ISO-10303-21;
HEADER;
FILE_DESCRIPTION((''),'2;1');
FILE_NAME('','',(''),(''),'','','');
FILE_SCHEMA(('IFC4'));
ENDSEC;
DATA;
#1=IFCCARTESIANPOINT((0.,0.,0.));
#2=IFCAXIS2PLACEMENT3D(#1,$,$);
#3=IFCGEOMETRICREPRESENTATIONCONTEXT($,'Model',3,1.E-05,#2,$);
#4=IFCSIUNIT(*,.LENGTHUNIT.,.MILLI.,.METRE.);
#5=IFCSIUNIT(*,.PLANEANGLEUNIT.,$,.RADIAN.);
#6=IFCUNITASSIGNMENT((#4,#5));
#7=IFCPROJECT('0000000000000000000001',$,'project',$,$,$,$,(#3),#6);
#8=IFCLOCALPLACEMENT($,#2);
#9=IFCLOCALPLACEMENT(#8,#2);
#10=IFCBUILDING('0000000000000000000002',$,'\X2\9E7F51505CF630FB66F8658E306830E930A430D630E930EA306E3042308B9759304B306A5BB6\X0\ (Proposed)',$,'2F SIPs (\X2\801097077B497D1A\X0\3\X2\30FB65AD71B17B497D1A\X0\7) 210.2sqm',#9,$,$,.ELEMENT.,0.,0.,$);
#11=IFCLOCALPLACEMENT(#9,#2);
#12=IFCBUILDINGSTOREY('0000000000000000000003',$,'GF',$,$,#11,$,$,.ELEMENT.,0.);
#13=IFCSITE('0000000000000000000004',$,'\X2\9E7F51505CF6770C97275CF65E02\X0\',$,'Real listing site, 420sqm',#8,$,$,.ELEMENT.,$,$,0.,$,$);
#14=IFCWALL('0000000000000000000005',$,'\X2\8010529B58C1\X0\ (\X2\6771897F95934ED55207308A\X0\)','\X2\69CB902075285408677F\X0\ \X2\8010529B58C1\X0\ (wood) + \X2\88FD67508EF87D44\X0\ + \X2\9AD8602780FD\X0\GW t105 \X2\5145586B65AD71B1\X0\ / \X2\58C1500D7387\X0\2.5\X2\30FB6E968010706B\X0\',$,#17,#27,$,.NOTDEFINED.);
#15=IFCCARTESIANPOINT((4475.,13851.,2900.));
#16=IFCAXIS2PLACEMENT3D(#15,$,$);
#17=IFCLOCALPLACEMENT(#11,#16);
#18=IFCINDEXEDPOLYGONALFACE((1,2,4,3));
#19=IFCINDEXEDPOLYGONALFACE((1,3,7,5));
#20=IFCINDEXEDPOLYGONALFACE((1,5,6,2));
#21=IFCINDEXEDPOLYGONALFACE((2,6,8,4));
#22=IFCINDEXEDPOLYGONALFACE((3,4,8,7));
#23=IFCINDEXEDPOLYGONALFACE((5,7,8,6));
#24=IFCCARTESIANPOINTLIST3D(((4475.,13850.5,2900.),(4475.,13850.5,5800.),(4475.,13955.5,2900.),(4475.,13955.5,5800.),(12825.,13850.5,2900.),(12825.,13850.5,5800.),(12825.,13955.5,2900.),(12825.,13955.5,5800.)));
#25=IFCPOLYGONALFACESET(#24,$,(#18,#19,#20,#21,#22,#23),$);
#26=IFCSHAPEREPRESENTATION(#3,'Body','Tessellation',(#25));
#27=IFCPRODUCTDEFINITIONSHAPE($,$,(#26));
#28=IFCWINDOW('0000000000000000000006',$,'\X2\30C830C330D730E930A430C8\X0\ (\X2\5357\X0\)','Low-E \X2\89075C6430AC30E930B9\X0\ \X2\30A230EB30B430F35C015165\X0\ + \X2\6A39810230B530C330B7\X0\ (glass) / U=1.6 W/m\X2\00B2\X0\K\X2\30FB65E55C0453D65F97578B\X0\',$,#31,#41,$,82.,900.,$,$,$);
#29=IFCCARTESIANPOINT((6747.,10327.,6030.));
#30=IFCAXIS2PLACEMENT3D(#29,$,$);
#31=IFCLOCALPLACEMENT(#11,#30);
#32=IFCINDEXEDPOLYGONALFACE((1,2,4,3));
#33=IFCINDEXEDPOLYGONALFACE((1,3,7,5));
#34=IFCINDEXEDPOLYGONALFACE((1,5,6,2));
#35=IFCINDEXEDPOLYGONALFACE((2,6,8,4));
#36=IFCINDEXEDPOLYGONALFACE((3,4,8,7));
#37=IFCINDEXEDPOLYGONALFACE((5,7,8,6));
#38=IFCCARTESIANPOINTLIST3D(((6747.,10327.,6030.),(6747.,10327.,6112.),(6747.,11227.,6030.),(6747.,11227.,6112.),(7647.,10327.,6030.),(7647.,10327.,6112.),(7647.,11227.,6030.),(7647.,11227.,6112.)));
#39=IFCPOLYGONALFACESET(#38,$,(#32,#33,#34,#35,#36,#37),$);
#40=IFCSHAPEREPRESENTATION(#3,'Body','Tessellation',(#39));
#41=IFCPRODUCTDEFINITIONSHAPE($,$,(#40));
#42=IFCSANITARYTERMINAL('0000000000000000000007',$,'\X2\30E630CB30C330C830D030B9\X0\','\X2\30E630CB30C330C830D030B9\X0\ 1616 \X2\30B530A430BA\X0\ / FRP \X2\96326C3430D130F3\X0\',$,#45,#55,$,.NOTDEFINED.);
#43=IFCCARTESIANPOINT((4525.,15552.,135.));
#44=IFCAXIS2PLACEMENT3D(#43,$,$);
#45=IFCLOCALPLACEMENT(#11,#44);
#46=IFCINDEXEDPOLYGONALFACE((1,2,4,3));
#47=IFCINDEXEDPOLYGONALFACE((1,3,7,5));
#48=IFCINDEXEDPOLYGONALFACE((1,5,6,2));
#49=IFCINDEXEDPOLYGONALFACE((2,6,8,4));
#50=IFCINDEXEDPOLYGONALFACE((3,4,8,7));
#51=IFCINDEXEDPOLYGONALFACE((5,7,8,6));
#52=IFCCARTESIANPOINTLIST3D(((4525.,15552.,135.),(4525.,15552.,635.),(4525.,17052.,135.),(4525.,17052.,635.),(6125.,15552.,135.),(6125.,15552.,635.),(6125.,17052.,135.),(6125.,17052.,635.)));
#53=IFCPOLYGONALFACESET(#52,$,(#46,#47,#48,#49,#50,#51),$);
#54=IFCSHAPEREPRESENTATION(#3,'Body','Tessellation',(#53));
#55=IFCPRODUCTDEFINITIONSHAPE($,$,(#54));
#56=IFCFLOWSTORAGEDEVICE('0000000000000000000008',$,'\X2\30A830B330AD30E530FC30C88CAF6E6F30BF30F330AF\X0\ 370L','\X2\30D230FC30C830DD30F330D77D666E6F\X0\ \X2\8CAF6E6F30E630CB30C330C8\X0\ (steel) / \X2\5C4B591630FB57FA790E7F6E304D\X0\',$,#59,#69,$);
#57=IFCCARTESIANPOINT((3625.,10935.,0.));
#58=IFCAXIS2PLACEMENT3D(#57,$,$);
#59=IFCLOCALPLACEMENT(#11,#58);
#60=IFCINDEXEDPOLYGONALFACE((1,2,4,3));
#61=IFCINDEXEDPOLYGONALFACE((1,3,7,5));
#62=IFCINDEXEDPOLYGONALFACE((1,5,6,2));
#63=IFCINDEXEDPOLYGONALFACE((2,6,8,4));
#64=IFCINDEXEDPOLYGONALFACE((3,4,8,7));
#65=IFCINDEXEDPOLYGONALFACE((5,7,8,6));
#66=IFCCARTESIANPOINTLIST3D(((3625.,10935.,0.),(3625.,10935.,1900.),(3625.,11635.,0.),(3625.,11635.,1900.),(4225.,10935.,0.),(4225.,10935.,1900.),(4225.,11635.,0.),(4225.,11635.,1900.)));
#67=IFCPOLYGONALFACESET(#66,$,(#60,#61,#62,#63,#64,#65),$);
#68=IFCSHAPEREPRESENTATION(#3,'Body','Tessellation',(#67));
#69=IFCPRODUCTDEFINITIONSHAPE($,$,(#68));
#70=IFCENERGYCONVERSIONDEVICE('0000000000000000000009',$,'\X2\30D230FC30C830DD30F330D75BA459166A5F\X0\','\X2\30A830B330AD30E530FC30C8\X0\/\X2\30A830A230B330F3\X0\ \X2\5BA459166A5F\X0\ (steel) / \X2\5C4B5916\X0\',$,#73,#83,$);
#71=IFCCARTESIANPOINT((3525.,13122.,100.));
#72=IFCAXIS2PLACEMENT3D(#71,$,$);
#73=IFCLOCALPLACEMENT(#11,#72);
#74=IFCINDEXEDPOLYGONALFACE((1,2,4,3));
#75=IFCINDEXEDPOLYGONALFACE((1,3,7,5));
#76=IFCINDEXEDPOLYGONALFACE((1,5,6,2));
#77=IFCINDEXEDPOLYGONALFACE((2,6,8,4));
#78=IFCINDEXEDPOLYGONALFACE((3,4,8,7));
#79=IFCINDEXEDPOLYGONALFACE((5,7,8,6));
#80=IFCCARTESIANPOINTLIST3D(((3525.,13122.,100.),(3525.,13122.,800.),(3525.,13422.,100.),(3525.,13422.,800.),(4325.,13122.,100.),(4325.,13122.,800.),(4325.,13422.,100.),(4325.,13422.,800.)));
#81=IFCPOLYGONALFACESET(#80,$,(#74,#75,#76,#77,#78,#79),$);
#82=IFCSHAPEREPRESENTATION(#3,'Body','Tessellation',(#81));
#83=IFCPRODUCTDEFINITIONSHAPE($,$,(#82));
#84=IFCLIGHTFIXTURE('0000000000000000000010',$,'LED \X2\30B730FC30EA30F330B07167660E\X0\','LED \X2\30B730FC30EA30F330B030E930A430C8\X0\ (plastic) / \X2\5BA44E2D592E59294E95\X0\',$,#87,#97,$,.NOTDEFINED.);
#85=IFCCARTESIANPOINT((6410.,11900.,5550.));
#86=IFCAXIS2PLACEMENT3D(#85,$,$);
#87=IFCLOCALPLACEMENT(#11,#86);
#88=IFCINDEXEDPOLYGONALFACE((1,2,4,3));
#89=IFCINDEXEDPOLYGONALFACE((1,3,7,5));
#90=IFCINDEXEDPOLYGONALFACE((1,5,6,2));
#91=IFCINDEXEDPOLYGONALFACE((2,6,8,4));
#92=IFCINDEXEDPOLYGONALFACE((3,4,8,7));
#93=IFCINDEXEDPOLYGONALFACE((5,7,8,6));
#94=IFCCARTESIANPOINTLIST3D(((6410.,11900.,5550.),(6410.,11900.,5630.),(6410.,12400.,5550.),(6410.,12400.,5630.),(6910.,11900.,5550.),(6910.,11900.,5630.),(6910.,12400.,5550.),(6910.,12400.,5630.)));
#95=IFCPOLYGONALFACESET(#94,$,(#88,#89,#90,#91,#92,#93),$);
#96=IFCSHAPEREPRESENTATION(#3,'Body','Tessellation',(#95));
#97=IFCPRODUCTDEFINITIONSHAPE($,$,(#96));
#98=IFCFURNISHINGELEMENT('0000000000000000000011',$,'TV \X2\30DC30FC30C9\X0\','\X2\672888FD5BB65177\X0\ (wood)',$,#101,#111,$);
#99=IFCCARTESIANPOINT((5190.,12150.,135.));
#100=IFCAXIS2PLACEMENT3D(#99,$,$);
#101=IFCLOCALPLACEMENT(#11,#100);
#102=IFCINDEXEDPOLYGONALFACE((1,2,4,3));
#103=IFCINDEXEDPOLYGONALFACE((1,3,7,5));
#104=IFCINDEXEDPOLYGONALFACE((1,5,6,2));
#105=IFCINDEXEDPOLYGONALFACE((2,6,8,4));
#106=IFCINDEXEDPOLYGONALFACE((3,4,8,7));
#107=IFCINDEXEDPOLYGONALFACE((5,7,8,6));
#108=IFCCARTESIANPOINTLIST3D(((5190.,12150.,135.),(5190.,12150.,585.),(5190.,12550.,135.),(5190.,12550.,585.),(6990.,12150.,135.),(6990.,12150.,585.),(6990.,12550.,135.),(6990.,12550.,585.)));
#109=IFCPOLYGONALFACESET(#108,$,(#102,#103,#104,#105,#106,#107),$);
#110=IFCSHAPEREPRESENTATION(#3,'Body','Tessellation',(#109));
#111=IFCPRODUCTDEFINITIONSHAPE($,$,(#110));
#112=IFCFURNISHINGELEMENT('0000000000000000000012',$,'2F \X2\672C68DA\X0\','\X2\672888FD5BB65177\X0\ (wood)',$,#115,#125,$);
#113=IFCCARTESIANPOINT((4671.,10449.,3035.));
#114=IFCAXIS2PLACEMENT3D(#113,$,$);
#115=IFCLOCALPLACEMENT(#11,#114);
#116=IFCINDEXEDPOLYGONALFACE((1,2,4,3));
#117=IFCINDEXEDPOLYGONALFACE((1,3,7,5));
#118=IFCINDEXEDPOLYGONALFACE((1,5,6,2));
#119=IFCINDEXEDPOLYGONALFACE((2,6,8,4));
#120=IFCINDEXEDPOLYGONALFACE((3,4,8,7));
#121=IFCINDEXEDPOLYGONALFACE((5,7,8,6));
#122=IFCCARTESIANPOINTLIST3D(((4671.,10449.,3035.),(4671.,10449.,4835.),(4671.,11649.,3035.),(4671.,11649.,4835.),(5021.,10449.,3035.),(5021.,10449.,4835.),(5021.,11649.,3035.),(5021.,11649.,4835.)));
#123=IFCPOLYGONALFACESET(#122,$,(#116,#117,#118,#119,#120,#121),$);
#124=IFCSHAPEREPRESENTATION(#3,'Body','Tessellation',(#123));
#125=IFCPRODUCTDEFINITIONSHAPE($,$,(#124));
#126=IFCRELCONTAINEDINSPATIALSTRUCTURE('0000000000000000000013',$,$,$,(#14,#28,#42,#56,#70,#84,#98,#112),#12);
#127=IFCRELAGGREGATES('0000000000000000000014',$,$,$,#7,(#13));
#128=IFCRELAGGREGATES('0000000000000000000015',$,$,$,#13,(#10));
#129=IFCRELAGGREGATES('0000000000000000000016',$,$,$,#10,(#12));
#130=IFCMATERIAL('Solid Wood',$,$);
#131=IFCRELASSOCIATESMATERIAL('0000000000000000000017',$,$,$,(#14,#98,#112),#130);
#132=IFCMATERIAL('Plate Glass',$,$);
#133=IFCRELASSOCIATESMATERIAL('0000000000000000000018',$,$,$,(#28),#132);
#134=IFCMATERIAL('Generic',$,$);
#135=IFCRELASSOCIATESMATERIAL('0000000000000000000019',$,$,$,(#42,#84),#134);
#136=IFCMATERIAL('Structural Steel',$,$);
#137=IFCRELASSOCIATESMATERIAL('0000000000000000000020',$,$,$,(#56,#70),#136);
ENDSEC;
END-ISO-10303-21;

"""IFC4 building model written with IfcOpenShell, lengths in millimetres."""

from ifc_helpers import new_model, si_unit, frame, frame_2d, origin, place, context, project, spatial, rectangle, extrude, material, element, save


model = new_model("IFC4")

# Units and contexts
model_context = context("Model", 3, precision=1e-05, world=origin())
ifc_project = project(units=[si_unit("LENGTHUNIT", "METRE", prefix="MILLI"), si_unit("PLANEANGLEUNIT", "RADIAN")], contexts=[model_context])

# Site, building, storey
site_placement = place(None, origin())
site = spatial("IfcSite", under=ifc_project, at=site_placement, Name="鹿児島県霧島市", ObjectType="Real listing site, 420sqm", CompositionType="ELEMENT", RefElevation=0.0)
building_placement = place(site_placement, origin())
building = spatial("IfcBuilding", under=site, at=building_placement, Name="鹿児島・書斎とライブラリのある静かな家 (Proposed)", ObjectType="2F SIPs (耐震等級3・断熱等級7) 210.2sqm", CompositionType="ELEMENT", ElevationOfRefHeight=0.0, ElevationOfTerrain=0.0)
storey_placement = place(building_placement, origin())
storey = spatial("IfcBuildingStorey", under=building, at=storey_placement, Name="GF", CompositionType="ELEMENT", Elevation=0.0)

# Shared definitions
ifc_material_1 = material(Name="Solid Wood")

# Wall
wall_1_placement = place(storey_placement, frame((4475.0, 13851.0, 2900.0)))
element("IfcWall", 1, at=wall_1_placement, inside=storey, material=ifc_material_1, Name="耐力壁 (東西間仕切り)", Description="構造用合板 耐力壁 (wood) + 製材軸組 + 高性能GW t105 充填断熱 / 壁倍率2.5・準耐火", PredefinedType="NOTDEFINED", context=model_context, shape_type="SweptSolid", body=[
    extrude(rectangle(XDim=8350.0, YDim=105.0, at=frame_2d((4175.0, 52.0))), frame((4475.0, 13851.0, 2900.0)), (0.0, 0.0, 1.0), 2900.0),
])

# Window
ifc_material_2 = material(Name="Plate Glass")
window_placement = place(storey_placement, frame((6747.0, 10327.0, 6030.0)))
element("IfcWindow", 2, at=window_placement, inside=storey, material=ifc_material_2, Name="トップライト (南)", Description="Low-E 複層ガラス アルゴン封入 + 樹脂サッシ (glass) / U=1.6 W/m²K・日射取得型", OverallHeight=82.0, OverallWidth=900.0, context=model_context, shape_type="SweptSolid", body=[
    extrude(rectangle(XDim=900.0, YDim=900.0, at=frame_2d((450.0, 450.0))), frame((6747.0, 10327.0, 6030.0)), (0.0, 0.0, 1.0), 82.0),
])

# Sanitary terminal
ifc_material_3 = material(Name="Generic")
sanitary_terminal_placement = place(storey_placement, frame((4525.0, 15552.0, 135.0)))
element("IfcSanitaryTerminal", 3, at=sanitary_terminal_placement, inside=storey, material=ifc_material_3, Name="ユニットバス", Description="ユニットバス 1616 サイズ / FRP 防水パン", PredefinedType="NOTDEFINED", context=model_context, shape_type="SweptSolid", body=[
    extrude(rectangle(XDim=1600.0, YDim=1500.0, at=frame_2d((800.0, 750.0))), frame((4525.0, 15552.0, 135.0)), (0.0, 0.0, 1.0), 500.0),
])

# Flow storage device
ifc_material_4 = material(Name="Structural Steel")
flow_storage_device_placement = place(storey_placement, frame((3625.0, 10935.0, 0.0)))
element("IfcFlowStorageDevice", 4, at=flow_storage_device_placement, inside=storey, material=ifc_material_4, Name="エコキュート貯湯タンク 370L", Description="ヒートポンプ給湯 貯湯ユニット (steel) / 屋外・基礎置き", context=model_context, shape_type="SweptSolid", body=[
    extrude(rectangle(XDim=600.0, YDim=700.0, at=frame_2d((300.0, 350.0))), frame((3625.0, 10935.0, 0.0)), (0.0, 0.0, 1.0), 1900.0),
])

# Energy conversion device
energy_conversion_device_placement = place(storey_placement, frame((3525.0, 13122.0, 100.0)))
element("IfcEnergyConversionDevice", 5, at=energy_conversion_device_placement, inside=storey, material=ifc_material_4, Name="ヒートポンプ室外機", Description="エコキュート/エアコン 室外機 (steel) / 屋外", context=model_context, shape_type="SweptSolid", body=[
    extrude(rectangle(XDim=800.0, YDim=300.0, at=frame_2d((400.0, 150.0))), frame((3525.0, 13122.0, 100.0)), (0.0, 0.0, 1.0), 700.0),
])

# Light fixture
light_fixture_placement = place(storey_placement, frame((6410.0, 11900.0, 5550.0)))
element("IfcLightFixture", 6, at=light_fixture_placement, inside=storey, material=ifc_material_3, Name="LED シーリング照明", Description="LED シーリングライト (plastic) / 室中央天井", PredefinedType="NOTDEFINED", context=model_context, shape_type="SweptSolid", body=[
    extrude(rectangle(XDim=500.0, YDim=500.0, at=frame_2d((250.0, 250.0))), frame((6410.0, 11900.0, 5550.0)), (0.0, 0.0, 1.0), 80.0),
])

# Furnishing elements
furnishing_1_placement = place(storey_placement, frame((5190.0, 12150.0, 135.0)))
element("IfcFurnishingElement", 7, at=furnishing_1_placement, inside=storey, material=ifc_material_1, Name="TV ボード", Description="木製家具 (wood)", context=model_context, shape_type="SweptSolid", body=[
    extrude(rectangle(XDim=1800.0, YDim=400.0, at=frame_2d((900.0, 200.0))), frame((5190.0, 12150.0, 135.0)), (0.0, 0.0, 1.0), 450.0),
])
furnishing_2_placement = place(storey_placement, frame((4671.0, 10449.0, 3035.0)))
element("IfcFurnishingElement", 8, at=furnishing_2_placement, inside=storey, material=ifc_material_1, Name="2F 本棚", Description="木製家具 (wood)", context=model_context, shape_type="SweptSolid", body=[
    extrude(rectangle(XDim=350.0, YDim=1200.0, at=frame_2d((175.0, 600.0))), frame((4671.0, 10449.0, 3035.0)), (0.0, 0.0, 1.0), 1800.0),
])

save(model, "model.ifc")
